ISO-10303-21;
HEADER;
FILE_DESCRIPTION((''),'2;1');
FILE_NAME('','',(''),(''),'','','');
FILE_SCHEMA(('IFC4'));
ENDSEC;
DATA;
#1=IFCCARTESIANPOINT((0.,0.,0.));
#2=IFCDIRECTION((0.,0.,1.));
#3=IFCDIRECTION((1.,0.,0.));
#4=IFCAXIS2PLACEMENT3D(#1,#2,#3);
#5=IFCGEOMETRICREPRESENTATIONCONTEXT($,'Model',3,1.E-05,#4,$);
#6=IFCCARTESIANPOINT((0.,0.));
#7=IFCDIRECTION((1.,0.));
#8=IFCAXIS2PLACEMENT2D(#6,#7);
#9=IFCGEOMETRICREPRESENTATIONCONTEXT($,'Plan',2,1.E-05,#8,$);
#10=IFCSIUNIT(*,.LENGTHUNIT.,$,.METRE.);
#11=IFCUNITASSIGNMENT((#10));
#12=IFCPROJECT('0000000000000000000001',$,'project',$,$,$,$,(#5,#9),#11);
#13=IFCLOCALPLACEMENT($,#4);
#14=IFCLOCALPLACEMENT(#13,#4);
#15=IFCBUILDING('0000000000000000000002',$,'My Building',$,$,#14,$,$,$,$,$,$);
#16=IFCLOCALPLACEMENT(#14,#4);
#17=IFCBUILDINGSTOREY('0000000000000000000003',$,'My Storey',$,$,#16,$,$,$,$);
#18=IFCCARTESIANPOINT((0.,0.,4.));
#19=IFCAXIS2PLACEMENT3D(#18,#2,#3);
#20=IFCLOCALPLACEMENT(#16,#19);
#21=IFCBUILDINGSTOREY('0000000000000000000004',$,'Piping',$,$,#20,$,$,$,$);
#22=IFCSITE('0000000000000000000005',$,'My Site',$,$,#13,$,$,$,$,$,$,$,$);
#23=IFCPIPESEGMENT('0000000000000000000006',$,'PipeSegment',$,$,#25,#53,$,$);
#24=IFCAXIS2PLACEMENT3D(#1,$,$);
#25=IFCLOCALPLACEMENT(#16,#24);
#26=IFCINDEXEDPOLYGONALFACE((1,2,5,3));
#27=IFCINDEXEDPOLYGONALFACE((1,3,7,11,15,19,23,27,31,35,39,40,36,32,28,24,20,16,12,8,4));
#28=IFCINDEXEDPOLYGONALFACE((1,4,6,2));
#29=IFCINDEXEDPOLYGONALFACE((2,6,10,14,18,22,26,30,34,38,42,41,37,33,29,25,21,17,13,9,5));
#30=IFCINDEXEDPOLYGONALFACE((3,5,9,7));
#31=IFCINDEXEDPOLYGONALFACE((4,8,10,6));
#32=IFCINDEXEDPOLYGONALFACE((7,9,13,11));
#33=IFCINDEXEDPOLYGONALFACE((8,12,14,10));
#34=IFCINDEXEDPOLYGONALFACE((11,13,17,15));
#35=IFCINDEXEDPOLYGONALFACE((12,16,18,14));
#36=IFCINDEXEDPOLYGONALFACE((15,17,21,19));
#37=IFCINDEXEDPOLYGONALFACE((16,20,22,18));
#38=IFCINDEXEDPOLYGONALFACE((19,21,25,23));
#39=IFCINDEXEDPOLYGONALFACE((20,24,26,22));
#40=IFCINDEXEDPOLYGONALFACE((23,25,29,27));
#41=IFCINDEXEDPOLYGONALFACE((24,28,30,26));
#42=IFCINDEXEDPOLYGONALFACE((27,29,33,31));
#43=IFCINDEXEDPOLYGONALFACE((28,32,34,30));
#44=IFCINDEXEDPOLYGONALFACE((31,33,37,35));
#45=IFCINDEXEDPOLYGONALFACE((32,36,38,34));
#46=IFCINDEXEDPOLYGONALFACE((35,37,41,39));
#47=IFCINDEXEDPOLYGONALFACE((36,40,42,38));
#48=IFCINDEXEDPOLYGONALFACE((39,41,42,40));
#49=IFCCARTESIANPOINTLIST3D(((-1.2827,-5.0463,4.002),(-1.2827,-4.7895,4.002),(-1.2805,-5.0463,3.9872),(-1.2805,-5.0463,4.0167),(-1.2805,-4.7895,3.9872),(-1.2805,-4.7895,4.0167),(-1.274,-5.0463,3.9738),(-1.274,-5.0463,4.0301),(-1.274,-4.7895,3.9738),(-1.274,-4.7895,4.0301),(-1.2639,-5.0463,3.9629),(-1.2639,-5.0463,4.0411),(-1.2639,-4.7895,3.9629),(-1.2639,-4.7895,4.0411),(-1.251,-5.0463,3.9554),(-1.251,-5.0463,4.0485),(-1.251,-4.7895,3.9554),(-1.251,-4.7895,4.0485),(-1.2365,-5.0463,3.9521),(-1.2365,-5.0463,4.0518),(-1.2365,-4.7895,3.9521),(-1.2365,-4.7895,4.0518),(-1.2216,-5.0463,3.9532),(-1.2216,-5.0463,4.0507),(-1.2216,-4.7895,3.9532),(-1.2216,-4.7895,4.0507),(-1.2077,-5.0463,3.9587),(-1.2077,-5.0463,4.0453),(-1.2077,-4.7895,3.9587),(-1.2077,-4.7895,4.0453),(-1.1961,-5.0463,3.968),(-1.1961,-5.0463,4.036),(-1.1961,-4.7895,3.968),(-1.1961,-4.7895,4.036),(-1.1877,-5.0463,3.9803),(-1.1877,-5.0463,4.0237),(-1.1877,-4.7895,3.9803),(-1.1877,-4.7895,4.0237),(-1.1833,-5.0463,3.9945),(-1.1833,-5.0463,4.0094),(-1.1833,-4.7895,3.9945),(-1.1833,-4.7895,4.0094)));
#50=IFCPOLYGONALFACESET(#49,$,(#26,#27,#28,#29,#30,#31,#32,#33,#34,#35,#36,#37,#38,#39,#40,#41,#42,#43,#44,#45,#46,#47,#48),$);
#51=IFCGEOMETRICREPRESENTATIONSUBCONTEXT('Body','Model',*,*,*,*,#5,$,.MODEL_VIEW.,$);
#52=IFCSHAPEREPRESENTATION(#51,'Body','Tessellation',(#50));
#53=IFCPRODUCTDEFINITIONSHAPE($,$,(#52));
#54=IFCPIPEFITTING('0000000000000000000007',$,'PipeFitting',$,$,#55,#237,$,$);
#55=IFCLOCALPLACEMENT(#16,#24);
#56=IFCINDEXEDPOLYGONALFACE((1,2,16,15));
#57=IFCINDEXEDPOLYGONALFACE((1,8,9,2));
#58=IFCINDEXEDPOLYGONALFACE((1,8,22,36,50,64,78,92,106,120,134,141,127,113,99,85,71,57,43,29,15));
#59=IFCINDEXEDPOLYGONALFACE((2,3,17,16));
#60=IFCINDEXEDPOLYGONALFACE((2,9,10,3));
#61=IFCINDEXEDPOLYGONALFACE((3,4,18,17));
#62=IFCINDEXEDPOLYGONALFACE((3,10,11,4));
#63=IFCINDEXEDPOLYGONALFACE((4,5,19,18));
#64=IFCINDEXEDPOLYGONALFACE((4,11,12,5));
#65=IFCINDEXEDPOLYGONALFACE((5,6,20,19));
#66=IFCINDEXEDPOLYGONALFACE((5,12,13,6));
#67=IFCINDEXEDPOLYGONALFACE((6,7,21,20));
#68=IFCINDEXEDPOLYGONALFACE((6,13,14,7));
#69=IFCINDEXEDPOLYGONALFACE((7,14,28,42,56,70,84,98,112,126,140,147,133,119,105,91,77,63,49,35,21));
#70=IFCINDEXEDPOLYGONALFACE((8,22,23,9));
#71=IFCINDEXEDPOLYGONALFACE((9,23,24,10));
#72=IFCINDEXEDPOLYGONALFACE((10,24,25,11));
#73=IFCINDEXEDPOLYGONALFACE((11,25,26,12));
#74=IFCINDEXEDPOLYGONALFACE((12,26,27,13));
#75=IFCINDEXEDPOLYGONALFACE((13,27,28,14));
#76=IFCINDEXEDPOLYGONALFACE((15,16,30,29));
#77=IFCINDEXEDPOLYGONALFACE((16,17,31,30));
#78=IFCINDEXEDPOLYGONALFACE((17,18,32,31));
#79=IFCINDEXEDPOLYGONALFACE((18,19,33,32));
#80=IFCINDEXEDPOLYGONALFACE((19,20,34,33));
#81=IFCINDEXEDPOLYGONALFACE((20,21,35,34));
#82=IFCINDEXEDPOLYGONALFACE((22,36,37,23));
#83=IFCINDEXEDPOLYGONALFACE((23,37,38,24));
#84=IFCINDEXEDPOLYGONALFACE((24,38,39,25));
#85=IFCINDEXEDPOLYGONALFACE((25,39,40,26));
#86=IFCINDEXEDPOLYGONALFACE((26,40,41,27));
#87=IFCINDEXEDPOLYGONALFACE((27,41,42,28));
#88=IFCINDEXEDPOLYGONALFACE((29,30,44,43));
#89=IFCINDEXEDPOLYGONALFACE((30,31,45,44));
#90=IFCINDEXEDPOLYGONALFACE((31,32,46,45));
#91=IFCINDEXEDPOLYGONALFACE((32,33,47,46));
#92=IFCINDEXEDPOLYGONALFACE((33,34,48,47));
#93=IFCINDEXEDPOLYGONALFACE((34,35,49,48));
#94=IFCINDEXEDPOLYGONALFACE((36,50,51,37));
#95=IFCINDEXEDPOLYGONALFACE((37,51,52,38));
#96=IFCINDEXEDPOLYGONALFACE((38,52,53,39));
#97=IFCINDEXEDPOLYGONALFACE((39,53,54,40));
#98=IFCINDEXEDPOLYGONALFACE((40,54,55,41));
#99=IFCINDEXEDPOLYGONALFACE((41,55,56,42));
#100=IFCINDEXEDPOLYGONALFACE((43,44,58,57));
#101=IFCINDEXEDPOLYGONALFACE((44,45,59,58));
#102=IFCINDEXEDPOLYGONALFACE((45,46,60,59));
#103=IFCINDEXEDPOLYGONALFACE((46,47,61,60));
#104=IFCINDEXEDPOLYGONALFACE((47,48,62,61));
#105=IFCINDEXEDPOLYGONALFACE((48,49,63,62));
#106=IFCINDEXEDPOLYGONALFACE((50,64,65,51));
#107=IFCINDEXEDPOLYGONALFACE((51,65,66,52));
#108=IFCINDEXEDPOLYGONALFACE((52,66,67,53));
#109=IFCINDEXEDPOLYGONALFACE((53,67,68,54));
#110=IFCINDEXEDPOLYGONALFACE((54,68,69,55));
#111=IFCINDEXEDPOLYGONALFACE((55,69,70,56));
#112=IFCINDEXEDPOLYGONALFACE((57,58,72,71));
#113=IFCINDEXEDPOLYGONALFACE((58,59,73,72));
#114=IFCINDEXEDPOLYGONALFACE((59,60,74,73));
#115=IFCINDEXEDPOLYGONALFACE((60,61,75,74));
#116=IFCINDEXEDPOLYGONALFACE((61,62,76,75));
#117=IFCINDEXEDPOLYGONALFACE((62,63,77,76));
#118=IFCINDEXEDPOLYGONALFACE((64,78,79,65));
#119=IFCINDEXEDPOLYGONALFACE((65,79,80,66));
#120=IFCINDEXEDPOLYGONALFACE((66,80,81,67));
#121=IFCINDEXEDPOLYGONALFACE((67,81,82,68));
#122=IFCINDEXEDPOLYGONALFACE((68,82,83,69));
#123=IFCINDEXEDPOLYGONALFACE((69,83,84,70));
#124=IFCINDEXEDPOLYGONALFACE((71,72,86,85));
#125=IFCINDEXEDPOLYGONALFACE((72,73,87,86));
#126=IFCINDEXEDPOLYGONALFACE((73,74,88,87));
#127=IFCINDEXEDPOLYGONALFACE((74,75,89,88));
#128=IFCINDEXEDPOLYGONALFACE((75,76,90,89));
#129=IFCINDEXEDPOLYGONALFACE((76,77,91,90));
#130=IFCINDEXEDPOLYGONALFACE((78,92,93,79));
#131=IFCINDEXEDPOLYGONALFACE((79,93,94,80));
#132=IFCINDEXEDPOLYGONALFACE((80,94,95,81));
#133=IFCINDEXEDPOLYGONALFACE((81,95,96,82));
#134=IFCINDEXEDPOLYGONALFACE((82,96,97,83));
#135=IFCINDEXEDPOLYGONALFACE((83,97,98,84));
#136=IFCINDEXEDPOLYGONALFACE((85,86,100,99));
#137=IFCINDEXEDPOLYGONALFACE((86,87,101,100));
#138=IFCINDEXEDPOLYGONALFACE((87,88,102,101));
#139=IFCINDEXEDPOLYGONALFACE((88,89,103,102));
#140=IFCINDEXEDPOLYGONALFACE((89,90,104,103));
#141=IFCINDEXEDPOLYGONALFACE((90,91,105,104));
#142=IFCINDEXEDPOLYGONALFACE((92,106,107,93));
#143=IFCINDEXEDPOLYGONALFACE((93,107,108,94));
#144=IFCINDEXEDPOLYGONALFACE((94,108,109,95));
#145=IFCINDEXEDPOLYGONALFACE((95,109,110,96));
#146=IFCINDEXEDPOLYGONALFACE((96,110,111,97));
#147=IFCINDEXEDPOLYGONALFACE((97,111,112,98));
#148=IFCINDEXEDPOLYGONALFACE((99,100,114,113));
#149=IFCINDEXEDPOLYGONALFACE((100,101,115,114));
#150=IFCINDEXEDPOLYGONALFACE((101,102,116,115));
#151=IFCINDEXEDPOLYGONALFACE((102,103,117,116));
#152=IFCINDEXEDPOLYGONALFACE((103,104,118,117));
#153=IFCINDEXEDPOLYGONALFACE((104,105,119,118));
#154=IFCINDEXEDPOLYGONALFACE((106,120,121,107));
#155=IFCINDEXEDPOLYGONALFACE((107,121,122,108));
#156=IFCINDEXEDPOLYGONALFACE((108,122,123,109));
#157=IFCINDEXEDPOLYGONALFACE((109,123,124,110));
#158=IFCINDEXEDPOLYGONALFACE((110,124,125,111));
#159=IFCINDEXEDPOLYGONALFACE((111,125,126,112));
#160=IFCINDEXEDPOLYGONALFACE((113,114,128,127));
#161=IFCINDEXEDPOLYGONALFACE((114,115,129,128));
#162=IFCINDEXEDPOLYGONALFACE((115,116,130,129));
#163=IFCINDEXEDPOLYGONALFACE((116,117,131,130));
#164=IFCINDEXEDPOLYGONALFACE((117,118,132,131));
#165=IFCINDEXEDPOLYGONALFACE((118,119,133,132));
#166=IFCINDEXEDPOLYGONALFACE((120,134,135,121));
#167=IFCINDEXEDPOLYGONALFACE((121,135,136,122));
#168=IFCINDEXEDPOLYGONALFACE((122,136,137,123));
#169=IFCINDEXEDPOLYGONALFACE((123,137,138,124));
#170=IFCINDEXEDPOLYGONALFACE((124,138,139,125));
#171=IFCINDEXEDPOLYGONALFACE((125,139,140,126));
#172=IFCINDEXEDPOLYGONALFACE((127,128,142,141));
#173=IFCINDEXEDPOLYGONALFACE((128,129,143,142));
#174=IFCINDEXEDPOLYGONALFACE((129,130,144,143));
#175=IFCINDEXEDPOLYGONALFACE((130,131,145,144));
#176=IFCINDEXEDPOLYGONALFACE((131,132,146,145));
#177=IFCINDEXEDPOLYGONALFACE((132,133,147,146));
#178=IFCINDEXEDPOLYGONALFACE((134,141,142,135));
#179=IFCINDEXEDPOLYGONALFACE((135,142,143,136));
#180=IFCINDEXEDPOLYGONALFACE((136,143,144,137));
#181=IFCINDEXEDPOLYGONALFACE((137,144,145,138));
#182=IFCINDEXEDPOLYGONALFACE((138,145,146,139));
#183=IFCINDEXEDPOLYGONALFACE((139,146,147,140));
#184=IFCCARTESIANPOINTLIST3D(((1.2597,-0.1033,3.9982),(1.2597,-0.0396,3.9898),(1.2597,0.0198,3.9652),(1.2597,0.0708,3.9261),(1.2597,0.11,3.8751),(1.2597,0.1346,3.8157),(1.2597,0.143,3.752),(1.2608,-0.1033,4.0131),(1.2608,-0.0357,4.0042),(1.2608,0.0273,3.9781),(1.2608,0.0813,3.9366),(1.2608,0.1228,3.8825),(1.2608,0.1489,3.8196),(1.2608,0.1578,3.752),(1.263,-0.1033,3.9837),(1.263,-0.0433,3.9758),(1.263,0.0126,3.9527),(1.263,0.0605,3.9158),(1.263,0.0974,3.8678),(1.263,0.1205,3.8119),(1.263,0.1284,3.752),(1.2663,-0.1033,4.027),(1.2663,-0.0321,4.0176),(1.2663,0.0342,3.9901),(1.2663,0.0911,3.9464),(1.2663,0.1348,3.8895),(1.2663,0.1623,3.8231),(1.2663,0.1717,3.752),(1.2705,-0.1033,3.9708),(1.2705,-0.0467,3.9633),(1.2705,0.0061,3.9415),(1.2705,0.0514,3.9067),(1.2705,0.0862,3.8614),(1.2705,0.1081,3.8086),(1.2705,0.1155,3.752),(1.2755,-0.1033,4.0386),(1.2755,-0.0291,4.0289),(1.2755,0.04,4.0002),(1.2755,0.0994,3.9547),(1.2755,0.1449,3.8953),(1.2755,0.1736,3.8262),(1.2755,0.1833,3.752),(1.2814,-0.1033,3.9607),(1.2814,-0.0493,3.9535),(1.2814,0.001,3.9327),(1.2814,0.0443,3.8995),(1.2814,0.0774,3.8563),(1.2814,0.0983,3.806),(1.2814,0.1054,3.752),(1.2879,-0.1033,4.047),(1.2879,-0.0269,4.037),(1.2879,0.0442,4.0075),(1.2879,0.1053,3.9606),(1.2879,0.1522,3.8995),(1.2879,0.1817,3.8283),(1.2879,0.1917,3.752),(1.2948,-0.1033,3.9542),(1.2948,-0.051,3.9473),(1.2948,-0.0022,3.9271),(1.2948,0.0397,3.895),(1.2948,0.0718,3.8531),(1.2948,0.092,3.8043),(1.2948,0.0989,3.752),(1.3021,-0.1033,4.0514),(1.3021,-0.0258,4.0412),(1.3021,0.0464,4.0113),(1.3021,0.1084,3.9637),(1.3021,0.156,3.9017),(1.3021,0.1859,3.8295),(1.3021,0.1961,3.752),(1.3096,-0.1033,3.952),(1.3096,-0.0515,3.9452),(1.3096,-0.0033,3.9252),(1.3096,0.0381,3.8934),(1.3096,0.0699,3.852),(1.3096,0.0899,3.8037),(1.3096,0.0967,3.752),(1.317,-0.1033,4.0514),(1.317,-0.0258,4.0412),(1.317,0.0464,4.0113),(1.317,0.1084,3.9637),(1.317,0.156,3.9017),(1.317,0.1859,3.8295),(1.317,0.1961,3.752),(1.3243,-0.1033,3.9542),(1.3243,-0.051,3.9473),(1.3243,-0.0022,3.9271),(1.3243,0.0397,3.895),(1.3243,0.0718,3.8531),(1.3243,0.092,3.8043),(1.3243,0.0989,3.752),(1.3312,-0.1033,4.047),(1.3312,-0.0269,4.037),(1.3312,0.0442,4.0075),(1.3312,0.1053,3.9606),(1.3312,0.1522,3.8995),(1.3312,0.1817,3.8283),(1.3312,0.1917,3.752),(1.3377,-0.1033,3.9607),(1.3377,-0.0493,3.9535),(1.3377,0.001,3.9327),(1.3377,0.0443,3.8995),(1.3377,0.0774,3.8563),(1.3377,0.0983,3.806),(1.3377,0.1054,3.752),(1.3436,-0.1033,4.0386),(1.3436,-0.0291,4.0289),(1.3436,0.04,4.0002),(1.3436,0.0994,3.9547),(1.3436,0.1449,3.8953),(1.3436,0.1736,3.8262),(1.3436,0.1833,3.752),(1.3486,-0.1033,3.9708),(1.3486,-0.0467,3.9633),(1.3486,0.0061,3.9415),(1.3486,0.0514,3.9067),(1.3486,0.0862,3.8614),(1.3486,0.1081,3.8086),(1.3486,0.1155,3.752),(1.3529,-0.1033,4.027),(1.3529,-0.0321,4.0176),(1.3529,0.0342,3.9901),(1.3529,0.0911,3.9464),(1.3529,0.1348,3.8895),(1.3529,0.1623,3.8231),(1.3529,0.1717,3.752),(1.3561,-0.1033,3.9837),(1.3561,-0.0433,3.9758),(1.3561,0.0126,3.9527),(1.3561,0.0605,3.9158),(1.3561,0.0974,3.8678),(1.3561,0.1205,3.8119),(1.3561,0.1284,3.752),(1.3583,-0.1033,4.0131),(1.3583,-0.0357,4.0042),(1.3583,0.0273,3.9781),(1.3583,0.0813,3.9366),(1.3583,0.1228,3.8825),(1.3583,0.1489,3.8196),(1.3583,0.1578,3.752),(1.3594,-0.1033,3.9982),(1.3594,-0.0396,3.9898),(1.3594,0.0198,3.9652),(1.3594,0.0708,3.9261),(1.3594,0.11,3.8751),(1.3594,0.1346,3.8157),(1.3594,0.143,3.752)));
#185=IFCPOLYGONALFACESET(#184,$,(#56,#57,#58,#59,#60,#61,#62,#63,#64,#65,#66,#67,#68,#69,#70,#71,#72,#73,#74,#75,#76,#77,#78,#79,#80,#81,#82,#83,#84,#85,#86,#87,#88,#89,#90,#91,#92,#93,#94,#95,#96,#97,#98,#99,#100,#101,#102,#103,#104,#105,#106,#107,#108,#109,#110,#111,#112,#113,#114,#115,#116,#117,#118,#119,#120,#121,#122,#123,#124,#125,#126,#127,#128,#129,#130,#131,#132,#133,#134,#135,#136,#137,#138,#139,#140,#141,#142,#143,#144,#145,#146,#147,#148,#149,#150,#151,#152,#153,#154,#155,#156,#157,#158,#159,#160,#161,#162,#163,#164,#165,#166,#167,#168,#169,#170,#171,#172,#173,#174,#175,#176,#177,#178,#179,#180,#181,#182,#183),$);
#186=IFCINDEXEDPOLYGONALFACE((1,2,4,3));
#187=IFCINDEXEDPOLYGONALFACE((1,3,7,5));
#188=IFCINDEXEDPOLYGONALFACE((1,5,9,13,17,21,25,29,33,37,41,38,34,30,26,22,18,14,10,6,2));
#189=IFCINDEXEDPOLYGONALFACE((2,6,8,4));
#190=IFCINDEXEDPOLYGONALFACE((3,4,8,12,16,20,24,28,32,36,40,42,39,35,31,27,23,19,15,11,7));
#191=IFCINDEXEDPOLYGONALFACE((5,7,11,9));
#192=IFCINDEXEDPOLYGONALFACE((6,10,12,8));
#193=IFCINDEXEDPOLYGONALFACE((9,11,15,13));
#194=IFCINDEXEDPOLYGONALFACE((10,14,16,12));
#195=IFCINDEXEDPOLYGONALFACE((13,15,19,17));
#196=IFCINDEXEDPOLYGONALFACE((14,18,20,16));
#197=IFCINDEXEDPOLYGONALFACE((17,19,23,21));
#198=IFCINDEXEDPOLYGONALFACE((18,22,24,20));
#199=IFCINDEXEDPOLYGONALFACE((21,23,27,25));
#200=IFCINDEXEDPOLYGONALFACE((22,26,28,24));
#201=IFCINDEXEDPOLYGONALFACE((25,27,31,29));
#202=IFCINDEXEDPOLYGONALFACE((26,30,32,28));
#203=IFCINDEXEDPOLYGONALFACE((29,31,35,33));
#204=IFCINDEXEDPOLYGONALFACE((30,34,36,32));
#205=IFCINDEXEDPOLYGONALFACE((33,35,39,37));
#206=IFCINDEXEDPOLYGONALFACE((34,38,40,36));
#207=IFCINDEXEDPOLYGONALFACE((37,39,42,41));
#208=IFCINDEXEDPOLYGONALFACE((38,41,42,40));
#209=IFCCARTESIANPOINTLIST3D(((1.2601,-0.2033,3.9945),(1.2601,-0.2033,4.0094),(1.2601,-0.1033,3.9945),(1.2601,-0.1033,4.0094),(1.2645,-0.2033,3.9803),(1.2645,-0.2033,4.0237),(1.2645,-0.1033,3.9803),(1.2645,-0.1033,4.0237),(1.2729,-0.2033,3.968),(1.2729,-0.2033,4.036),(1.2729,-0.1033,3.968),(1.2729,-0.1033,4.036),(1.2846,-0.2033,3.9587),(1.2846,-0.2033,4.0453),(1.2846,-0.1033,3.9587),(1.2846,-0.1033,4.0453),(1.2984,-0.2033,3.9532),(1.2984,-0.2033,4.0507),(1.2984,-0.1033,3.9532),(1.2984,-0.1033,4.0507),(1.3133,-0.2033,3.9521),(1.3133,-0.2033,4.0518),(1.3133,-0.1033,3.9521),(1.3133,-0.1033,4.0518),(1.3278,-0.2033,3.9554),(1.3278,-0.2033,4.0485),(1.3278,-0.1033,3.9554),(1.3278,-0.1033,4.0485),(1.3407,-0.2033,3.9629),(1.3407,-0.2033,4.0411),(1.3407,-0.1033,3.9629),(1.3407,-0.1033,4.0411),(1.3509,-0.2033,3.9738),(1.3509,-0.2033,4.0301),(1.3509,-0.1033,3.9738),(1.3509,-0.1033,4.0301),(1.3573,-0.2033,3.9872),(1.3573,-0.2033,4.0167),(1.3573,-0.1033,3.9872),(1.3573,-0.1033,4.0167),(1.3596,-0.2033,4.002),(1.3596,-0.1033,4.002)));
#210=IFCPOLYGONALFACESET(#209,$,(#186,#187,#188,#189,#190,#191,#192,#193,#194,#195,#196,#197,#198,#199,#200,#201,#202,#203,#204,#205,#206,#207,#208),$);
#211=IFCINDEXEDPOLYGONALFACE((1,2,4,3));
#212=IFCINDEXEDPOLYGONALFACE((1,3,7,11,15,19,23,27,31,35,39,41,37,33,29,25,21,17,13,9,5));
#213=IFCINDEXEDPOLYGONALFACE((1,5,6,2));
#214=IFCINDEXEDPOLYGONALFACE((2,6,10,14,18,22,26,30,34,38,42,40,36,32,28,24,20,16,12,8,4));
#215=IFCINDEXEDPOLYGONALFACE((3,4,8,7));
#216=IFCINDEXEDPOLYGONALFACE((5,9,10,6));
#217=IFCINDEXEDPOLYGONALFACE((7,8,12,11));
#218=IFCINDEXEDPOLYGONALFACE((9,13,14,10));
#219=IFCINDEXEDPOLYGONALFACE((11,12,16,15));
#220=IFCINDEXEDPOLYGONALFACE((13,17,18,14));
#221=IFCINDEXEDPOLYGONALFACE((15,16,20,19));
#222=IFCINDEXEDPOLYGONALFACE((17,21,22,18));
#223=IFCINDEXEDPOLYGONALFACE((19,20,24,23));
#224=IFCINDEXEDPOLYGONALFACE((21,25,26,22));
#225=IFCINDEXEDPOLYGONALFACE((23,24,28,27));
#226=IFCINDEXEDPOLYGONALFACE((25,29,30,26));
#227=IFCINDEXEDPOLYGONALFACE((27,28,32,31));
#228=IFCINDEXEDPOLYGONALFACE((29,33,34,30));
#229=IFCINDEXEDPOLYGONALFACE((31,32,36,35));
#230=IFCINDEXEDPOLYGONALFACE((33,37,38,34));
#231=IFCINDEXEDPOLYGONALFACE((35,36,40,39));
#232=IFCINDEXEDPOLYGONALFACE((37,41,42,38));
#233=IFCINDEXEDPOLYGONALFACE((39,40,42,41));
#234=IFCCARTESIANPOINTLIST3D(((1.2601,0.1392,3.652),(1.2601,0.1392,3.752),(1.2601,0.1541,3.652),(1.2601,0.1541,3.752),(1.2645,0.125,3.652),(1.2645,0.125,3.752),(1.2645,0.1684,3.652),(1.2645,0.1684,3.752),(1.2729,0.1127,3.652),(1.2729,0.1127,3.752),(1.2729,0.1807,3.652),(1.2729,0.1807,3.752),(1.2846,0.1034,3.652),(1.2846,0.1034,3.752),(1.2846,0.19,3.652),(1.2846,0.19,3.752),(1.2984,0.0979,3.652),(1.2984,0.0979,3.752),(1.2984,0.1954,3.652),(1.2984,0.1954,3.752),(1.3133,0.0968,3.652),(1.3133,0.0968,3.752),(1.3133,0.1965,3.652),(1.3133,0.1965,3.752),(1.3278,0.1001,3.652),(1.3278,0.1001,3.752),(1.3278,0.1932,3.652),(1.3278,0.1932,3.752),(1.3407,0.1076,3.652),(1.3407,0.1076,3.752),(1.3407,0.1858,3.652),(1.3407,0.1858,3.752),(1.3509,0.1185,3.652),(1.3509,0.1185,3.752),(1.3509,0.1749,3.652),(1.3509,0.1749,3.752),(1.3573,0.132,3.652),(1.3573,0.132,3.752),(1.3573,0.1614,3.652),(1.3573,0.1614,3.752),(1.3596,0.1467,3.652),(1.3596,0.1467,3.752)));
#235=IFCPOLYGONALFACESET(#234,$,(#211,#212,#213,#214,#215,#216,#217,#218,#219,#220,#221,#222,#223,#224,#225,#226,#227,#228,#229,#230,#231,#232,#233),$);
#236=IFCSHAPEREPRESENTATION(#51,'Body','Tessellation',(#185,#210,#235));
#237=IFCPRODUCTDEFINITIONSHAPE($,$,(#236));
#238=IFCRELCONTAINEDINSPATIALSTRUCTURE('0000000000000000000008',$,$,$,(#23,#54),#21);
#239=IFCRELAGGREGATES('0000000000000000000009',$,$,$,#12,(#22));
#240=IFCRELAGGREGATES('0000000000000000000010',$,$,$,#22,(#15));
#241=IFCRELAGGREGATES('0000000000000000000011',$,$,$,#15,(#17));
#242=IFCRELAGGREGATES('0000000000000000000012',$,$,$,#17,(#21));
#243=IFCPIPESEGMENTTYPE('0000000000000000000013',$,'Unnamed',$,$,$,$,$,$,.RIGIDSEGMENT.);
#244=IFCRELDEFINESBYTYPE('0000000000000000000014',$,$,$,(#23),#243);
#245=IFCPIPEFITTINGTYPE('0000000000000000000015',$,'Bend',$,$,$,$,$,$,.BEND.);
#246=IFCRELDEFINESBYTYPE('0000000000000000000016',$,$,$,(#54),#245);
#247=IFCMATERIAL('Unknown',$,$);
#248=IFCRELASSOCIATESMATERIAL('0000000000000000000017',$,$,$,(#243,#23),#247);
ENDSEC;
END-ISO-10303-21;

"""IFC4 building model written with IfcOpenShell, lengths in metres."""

from ifc_helpers import new_model, entity, si_unit, frame, origin_with_axes, origin_2d_with_axis, place, context, subcontext, project, spatial, circle, extrude, source, transform, mapped, material, material_profile, profile_set, profile_usage, type_object, type_shapes, element, save


model = new_model("IFC4")

# Units and contexts
model_context = context("Model", 3, precision=1e-05, world=origin_with_axes())
plan_context = context("Plan", 2, precision=1e-05, world=origin_2d_with_axis())
body_context = subcontext(model_context, "Body", "Model", "MODEL_VIEW")
ifc_project = project(units=[si_unit("LENGTHUNIT", "METRE")], contexts=[model_context, plan_context])

# Site, building, storeys
site_placement = place(None, origin_with_axes())
site = spatial("IfcSite", under=ifc_project, at=site_placement, Name="My Site")
building_placement = place(site_placement, origin_with_axes())
building = spatial("IfcBuilding", under=site, at=building_placement, Name="My Building")
storey_1_placement = place(building_placement, origin_with_axes())
storey_1 = spatial("IfcBuildingStorey", under=building, at=storey_1_placement, Name="My Storey")
storey_2_placement = place(storey_1_placement, frame((0.0, 0.0, 4.0), z_axis=(0.0, 0.0, 1.0), x_axis=(1.0, 0.0, 0.0)))
storey_2 = spatial("IfcBuildingStorey", under=storey_1, at=storey_2_placement, Name="Piping")

# Pipe segment
ifc_material = material(Name="Unknown")
ifc_material_profile_1 = material_profile(ifc_material, circle(Radius=0.05))
ifc_profile_set_1 = profile_set([ifc_material_profile_1])
pipe_segment_type = type_object("IfcPipeSegmentType", Name="Unnamed", PredefinedType="RIGIDSEGMENT", material=ifc_profile_set_1)
ifc_profile_usage_1 = profile_usage(ifc_profile_set_1, cardinal=5)
pipe_segment_1_placement = place(storey_2_placement, frame((-1.2327, -5.0463, 0.002), z_axis=(0.0, 1.0, 0.000001), x_axis=(-1.0, 0.0, 0.0)))
element("IfcPipeSegment", 1, at=pipe_segment_1_placement, inside=storey_2, type_object=pipe_segment_type, material=ifc_profile_usage_1, Name="PipeSegment", context=body_context, shape_type="SweptSolid", body=[
    extrude(circle(Radius=0.05), origin_with_axes(), (0.0, 0.0, 1.0), 0.2568),
])

# Pipe fitting
pipe_fitting_type_1 = type_object("IfcPipeFittingType", Name="Bend", PredefinedType="BEND")
shared_shape = source(origin_with_axes(), body_context, "Body", "SolidModel", [
    entity("IfcSweptDiskSolid", entity("IfcIndexedPolyCurve", entity("IfcCartesianPointList3D", [[0.0, 0.0, -0.1], [0.0, -0.0732, -0.2768], [0.0, -0.25, -0.35]]), [entity("IfcArcIndex", [1, 2, 3])]), 0.05),
    extrude(circle(Radius=0.05), origin_with_axes(), (0.0, 0.0, -1.0), 0.1),
    extrude(circle(Radius=0.05), frame((0.0, -0.25, -0.35), z_axis=(0.0, -1.0, 0.0), x_axis=(1.0, 0.0, 0.0)), (0.0, 0.0, 1.0), 0.1),
])
type_shapes(pipe_fitting_type_1, [shared_shape])
pipe_fitting_1_placement = place(storey_2_placement, frame((1.3096, -0.2033, 0.002), z_axis=(0.0, -1.0, 0.0), x_axis=(1.0, 0.0, 0.0)))
element("IfcPipeFitting", 2, at=pipe_fitting_1_placement, inside=storey_2, type_object=pipe_fitting_type_1, Name="PipeFitting", context=body_context, shape_type="MappedRepresentation", body=[
    mapped(shared_shape, transform((0.0, 0.0, 0.0), x_axis=(1.0, 0.0, 0.0), y_axis=(0.0, 1.0, 0.0), z_axis=(0.0, 0.0, 1.0), scale=1.0)),
])

save(model, "model.ifc")
